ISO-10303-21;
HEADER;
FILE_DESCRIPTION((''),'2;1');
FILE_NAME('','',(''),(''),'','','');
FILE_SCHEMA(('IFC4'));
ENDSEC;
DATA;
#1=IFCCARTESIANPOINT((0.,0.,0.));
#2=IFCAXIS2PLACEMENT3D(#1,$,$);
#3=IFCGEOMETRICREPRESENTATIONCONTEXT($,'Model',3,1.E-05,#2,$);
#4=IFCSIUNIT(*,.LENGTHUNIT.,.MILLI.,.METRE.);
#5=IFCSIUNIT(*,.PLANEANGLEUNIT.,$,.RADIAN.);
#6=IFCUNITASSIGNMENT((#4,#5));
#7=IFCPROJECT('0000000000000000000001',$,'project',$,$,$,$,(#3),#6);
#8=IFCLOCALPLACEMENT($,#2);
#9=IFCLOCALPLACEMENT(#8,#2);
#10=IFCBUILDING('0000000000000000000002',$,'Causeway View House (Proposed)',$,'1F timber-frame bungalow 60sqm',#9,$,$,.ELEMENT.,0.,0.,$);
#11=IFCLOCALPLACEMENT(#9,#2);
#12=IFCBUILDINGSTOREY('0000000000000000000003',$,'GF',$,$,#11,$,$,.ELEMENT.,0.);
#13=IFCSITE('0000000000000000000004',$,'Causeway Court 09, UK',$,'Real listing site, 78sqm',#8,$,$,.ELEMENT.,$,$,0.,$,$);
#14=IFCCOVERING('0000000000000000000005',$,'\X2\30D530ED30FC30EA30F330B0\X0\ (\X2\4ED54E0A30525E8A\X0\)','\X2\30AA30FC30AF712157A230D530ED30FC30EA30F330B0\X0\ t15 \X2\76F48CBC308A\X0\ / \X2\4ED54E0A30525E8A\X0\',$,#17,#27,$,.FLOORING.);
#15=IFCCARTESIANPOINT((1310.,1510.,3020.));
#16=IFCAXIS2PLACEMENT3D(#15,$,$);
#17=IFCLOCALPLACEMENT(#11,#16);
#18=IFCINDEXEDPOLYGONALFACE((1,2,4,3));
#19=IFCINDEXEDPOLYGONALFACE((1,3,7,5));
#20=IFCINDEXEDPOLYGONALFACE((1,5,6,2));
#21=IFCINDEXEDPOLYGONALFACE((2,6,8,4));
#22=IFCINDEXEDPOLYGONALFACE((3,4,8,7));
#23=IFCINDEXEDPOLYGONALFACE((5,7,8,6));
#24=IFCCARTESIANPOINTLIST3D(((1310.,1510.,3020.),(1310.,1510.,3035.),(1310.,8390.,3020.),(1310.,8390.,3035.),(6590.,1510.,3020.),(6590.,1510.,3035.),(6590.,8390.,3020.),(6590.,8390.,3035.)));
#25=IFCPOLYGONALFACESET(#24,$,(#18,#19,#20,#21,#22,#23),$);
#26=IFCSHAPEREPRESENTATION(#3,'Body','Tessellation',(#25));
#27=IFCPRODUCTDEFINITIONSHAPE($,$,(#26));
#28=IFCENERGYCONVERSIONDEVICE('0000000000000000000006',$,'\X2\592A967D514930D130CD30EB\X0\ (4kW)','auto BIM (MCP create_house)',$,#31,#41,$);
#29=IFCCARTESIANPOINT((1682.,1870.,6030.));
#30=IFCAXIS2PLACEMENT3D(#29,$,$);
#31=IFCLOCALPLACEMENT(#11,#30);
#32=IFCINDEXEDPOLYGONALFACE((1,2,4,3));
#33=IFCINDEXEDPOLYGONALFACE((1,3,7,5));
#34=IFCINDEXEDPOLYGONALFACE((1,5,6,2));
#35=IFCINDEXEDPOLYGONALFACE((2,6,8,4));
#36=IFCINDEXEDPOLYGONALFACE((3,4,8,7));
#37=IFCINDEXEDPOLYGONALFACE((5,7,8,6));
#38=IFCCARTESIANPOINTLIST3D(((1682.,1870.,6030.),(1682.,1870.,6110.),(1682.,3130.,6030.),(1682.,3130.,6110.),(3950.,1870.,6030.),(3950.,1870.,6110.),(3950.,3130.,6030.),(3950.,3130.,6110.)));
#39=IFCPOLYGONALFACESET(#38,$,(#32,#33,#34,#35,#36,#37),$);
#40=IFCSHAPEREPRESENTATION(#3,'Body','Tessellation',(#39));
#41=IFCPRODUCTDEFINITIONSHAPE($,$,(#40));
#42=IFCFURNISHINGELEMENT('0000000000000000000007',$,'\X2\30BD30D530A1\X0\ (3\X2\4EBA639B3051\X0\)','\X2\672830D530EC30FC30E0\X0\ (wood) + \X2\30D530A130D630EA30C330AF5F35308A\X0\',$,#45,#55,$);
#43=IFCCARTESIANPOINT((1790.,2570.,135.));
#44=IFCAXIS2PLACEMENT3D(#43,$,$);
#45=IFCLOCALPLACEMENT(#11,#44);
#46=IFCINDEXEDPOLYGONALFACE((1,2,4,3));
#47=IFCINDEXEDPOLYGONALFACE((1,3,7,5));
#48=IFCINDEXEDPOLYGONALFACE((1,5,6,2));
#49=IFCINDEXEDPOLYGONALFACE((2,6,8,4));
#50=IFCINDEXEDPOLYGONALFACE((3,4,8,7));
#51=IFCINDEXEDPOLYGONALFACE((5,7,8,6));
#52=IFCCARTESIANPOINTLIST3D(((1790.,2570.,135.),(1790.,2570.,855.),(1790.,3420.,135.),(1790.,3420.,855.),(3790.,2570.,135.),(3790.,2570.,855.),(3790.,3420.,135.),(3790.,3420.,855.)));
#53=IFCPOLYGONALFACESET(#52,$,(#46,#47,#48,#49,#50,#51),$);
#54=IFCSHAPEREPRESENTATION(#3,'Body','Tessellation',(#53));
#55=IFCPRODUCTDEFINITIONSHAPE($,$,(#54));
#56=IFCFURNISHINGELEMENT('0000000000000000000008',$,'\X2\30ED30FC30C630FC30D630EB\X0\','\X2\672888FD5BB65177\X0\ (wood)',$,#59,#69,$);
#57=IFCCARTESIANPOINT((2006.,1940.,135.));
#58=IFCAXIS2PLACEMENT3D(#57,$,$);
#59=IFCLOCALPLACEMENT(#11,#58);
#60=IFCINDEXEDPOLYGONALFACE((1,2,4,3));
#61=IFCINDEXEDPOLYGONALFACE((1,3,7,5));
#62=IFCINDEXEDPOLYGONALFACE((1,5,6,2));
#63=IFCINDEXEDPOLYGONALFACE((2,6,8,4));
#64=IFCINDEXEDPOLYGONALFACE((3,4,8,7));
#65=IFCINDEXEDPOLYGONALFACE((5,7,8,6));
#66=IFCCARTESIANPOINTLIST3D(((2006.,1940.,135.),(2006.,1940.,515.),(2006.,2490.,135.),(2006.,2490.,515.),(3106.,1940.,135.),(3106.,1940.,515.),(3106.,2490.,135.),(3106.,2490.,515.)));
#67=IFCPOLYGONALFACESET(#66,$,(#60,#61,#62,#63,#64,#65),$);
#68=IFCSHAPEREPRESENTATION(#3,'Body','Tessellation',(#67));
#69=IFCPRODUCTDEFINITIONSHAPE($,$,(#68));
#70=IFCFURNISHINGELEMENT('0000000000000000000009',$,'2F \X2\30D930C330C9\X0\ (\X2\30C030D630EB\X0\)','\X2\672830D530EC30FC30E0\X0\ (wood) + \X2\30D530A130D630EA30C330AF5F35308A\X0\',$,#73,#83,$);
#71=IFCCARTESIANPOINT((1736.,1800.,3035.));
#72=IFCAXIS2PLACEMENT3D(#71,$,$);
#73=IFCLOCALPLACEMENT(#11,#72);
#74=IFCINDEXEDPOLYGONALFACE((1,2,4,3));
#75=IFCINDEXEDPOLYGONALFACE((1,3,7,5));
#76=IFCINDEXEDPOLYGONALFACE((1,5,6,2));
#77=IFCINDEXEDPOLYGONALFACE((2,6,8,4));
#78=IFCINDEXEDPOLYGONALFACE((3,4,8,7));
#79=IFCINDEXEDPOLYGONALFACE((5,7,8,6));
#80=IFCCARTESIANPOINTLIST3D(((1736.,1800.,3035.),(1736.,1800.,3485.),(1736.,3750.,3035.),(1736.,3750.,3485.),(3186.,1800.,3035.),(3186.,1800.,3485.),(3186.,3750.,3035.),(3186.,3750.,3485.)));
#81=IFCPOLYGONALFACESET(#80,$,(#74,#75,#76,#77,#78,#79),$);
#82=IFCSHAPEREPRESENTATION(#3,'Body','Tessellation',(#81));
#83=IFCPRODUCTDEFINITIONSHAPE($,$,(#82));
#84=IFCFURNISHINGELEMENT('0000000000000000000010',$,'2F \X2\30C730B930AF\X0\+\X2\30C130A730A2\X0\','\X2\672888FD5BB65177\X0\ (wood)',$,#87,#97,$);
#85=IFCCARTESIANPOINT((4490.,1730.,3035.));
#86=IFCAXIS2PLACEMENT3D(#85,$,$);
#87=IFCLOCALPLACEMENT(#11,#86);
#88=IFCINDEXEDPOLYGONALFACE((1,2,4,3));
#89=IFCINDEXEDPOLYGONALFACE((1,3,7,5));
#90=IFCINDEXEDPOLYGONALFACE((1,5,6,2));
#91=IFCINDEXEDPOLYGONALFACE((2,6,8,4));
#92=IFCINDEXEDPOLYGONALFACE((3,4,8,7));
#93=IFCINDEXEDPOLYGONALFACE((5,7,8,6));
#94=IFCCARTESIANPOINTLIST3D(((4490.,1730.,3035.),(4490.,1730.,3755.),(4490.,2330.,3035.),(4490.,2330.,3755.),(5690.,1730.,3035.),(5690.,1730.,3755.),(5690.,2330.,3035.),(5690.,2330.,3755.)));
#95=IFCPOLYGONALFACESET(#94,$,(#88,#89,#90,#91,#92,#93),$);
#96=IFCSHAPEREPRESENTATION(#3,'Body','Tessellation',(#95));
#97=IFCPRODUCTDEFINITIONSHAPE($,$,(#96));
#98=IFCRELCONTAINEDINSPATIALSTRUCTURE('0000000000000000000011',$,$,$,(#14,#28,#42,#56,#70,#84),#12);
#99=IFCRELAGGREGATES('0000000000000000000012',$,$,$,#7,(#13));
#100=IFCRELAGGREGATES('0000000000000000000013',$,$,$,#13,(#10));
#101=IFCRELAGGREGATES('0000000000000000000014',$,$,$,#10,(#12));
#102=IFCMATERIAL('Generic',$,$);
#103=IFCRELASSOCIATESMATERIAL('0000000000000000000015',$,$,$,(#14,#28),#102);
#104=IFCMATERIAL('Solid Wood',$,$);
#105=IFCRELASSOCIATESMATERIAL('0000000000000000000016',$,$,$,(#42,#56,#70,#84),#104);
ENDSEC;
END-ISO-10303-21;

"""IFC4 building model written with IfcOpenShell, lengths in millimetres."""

from ifc_helpers import new_model, si_unit, frame, frame_2d, origin, place, context, project, spatial, rectangle, extrude, material, element, save


model = new_model("IFC4")

# Units and contexts
model_context = context("Model", 3, precision=1e-05, world=origin())
ifc_project = project(units=[si_unit("LENGTHUNIT", "METRE", prefix="MILLI"), si_unit("PLANEANGLEUNIT", "RADIAN")], contexts=[model_context])

# Site, building, storey
site_placement = place(None, origin())
site = spatial("IfcSite", under=ifc_project, at=site_placement, Name="Causeway Court 09, UK", ObjectType="Real listing site, 78sqm", CompositionType="ELEMENT", RefElevation=0.0)
building_placement = place(site_placement, origin())
building = spatial("IfcBuilding", under=site, at=building_placement, Name="Causeway View House (Proposed)", ObjectType="1F timber-frame bungalow 60sqm", CompositionType="ELEMENT", ElevationOfRefHeight=0.0, ElevationOfTerrain=0.0)
storey_placement = place(building_placement, origin())
storey = spatial("IfcBuildingStorey", under=building, at=storey_placement, Name="GF", CompositionType="ELEMENT", Elevation=0.0)

# Shared definitions
ifc_material_1 = material(Name="Solid Wood")

# Shared definitions
ifc_material_2 = material(Name="Generic")

# Covering
covering_placement = place(storey_placement, frame((1310.0, 1510.0, 3020.0)))
element("IfcCovering", 1, at=covering_placement, inside=storey, material=ifc_material_2, Name="フローリング (仕上げ床)", Description="オーク無垢フローリング t15 直貼り / 仕上げ床", PredefinedType="FLOORING", context=model_context, shape_type="SweptSolid", body=[
    extrude(rectangle(XDim=5280.0, YDim=6880.0, at=frame_2d((2640.0, 3440.0))), frame((1310.0, 1510.0, 3020.0)), (0.0, 0.0, 1.0), 15.0),
])

# Energy conversion device
energy_conversion_device_placement = place(storey_placement, frame((1682.0, 1870.0, 6030.0)))
element("IfcEnergyConversionDevice", 2, at=energy_conversion_device_placement, inside=storey, material=ifc_material_2, Name="太陽光パネル (4kW)", Description="auto BIM (MCP create_house)", context=model_context, shape_type="SweptSolid", body=[
    extrude(rectangle(XDim=2268.0, YDim=1260.0, at=frame_2d((1134.0, 630.0))), frame((1682.0, 1870.0, 6030.0)), (0.0, 0.0, 1.0), 80.0),
])

# Furnishing elements
furnishing_1_placement = place(storey_placement, frame((1790.0, 2570.0, 135.0)))
element("IfcFurnishingElement", 3, at=furnishing_1_placement, inside=storey, material=ifc_material_1, Name="ソファ (3人掛け)", Description="木フレーム (wood) + ファブリック張り", context=model_context, shape_type="SweptSolid", body=[
    extrude(rectangle(XDim=2000.0, YDim=850.0, at=frame_2d((1000.0, 425.0))), frame((1790.0, 2570.0, 135.0)), (0.0, 0.0, 1.0), 720.0),
])
furnishing_2_placement = place(storey_placement, frame((2006.0, 1940.0, 135.0)))
element("IfcFurnishingElement", 4, at=furnishing_2_placement, inside=storey, material=ifc_material_1, Name="ローテーブル", Description="木製家具 (wood)", context=model_context, shape_type="SweptSolid", body=[
    extrude(rectangle(XDim=1100.0, YDim=550.0, at=frame_2d((550.0, 275.0))), frame((2006.0, 1940.0, 135.0)), (0.0, 0.0, 1.0), 380.0),
])
furnishing_3_placement = place(storey_placement, frame((1736.0, 1800.0, 3035.0)))
element("IfcFurnishingElement", 5, at=furnishing_3_placement, inside=storey, material=ifc_material_1, Name="2F ベッド (ダブル)", Description="木フレーム (wood) + ファブリック張り", context=model_context, shape_type="SweptSolid", body=[
    extrude(rectangle(XDim=1450.0, YDim=1950.0, at=frame_2d((725.0, 975.0))), frame((1736.0, 1800.0, 3035.0)), (0.0, 0.0, 1.0), 450.0),
])
furnishing_4_placement = place(storey_placement, frame((4490.0, 1730.0, 3035.0)))
element("IfcFurnishingElement", 6, at=furnishing_4_placement, inside=storey, material=ifc_material_1, Name="2F デスク+チェア", Description="木製家具 (wood)", context=model_context, shape_type="SweptSolid", body=[
    extrude(rectangle(XDim=1200.0, YDim=600.0, at=frame_2d((600.0, 300.0))), frame((4490.0, 1730.0, 3035.0)), (0.0, 0.0, 1.0), 720.0),
])

save(model, "model.ifc")
